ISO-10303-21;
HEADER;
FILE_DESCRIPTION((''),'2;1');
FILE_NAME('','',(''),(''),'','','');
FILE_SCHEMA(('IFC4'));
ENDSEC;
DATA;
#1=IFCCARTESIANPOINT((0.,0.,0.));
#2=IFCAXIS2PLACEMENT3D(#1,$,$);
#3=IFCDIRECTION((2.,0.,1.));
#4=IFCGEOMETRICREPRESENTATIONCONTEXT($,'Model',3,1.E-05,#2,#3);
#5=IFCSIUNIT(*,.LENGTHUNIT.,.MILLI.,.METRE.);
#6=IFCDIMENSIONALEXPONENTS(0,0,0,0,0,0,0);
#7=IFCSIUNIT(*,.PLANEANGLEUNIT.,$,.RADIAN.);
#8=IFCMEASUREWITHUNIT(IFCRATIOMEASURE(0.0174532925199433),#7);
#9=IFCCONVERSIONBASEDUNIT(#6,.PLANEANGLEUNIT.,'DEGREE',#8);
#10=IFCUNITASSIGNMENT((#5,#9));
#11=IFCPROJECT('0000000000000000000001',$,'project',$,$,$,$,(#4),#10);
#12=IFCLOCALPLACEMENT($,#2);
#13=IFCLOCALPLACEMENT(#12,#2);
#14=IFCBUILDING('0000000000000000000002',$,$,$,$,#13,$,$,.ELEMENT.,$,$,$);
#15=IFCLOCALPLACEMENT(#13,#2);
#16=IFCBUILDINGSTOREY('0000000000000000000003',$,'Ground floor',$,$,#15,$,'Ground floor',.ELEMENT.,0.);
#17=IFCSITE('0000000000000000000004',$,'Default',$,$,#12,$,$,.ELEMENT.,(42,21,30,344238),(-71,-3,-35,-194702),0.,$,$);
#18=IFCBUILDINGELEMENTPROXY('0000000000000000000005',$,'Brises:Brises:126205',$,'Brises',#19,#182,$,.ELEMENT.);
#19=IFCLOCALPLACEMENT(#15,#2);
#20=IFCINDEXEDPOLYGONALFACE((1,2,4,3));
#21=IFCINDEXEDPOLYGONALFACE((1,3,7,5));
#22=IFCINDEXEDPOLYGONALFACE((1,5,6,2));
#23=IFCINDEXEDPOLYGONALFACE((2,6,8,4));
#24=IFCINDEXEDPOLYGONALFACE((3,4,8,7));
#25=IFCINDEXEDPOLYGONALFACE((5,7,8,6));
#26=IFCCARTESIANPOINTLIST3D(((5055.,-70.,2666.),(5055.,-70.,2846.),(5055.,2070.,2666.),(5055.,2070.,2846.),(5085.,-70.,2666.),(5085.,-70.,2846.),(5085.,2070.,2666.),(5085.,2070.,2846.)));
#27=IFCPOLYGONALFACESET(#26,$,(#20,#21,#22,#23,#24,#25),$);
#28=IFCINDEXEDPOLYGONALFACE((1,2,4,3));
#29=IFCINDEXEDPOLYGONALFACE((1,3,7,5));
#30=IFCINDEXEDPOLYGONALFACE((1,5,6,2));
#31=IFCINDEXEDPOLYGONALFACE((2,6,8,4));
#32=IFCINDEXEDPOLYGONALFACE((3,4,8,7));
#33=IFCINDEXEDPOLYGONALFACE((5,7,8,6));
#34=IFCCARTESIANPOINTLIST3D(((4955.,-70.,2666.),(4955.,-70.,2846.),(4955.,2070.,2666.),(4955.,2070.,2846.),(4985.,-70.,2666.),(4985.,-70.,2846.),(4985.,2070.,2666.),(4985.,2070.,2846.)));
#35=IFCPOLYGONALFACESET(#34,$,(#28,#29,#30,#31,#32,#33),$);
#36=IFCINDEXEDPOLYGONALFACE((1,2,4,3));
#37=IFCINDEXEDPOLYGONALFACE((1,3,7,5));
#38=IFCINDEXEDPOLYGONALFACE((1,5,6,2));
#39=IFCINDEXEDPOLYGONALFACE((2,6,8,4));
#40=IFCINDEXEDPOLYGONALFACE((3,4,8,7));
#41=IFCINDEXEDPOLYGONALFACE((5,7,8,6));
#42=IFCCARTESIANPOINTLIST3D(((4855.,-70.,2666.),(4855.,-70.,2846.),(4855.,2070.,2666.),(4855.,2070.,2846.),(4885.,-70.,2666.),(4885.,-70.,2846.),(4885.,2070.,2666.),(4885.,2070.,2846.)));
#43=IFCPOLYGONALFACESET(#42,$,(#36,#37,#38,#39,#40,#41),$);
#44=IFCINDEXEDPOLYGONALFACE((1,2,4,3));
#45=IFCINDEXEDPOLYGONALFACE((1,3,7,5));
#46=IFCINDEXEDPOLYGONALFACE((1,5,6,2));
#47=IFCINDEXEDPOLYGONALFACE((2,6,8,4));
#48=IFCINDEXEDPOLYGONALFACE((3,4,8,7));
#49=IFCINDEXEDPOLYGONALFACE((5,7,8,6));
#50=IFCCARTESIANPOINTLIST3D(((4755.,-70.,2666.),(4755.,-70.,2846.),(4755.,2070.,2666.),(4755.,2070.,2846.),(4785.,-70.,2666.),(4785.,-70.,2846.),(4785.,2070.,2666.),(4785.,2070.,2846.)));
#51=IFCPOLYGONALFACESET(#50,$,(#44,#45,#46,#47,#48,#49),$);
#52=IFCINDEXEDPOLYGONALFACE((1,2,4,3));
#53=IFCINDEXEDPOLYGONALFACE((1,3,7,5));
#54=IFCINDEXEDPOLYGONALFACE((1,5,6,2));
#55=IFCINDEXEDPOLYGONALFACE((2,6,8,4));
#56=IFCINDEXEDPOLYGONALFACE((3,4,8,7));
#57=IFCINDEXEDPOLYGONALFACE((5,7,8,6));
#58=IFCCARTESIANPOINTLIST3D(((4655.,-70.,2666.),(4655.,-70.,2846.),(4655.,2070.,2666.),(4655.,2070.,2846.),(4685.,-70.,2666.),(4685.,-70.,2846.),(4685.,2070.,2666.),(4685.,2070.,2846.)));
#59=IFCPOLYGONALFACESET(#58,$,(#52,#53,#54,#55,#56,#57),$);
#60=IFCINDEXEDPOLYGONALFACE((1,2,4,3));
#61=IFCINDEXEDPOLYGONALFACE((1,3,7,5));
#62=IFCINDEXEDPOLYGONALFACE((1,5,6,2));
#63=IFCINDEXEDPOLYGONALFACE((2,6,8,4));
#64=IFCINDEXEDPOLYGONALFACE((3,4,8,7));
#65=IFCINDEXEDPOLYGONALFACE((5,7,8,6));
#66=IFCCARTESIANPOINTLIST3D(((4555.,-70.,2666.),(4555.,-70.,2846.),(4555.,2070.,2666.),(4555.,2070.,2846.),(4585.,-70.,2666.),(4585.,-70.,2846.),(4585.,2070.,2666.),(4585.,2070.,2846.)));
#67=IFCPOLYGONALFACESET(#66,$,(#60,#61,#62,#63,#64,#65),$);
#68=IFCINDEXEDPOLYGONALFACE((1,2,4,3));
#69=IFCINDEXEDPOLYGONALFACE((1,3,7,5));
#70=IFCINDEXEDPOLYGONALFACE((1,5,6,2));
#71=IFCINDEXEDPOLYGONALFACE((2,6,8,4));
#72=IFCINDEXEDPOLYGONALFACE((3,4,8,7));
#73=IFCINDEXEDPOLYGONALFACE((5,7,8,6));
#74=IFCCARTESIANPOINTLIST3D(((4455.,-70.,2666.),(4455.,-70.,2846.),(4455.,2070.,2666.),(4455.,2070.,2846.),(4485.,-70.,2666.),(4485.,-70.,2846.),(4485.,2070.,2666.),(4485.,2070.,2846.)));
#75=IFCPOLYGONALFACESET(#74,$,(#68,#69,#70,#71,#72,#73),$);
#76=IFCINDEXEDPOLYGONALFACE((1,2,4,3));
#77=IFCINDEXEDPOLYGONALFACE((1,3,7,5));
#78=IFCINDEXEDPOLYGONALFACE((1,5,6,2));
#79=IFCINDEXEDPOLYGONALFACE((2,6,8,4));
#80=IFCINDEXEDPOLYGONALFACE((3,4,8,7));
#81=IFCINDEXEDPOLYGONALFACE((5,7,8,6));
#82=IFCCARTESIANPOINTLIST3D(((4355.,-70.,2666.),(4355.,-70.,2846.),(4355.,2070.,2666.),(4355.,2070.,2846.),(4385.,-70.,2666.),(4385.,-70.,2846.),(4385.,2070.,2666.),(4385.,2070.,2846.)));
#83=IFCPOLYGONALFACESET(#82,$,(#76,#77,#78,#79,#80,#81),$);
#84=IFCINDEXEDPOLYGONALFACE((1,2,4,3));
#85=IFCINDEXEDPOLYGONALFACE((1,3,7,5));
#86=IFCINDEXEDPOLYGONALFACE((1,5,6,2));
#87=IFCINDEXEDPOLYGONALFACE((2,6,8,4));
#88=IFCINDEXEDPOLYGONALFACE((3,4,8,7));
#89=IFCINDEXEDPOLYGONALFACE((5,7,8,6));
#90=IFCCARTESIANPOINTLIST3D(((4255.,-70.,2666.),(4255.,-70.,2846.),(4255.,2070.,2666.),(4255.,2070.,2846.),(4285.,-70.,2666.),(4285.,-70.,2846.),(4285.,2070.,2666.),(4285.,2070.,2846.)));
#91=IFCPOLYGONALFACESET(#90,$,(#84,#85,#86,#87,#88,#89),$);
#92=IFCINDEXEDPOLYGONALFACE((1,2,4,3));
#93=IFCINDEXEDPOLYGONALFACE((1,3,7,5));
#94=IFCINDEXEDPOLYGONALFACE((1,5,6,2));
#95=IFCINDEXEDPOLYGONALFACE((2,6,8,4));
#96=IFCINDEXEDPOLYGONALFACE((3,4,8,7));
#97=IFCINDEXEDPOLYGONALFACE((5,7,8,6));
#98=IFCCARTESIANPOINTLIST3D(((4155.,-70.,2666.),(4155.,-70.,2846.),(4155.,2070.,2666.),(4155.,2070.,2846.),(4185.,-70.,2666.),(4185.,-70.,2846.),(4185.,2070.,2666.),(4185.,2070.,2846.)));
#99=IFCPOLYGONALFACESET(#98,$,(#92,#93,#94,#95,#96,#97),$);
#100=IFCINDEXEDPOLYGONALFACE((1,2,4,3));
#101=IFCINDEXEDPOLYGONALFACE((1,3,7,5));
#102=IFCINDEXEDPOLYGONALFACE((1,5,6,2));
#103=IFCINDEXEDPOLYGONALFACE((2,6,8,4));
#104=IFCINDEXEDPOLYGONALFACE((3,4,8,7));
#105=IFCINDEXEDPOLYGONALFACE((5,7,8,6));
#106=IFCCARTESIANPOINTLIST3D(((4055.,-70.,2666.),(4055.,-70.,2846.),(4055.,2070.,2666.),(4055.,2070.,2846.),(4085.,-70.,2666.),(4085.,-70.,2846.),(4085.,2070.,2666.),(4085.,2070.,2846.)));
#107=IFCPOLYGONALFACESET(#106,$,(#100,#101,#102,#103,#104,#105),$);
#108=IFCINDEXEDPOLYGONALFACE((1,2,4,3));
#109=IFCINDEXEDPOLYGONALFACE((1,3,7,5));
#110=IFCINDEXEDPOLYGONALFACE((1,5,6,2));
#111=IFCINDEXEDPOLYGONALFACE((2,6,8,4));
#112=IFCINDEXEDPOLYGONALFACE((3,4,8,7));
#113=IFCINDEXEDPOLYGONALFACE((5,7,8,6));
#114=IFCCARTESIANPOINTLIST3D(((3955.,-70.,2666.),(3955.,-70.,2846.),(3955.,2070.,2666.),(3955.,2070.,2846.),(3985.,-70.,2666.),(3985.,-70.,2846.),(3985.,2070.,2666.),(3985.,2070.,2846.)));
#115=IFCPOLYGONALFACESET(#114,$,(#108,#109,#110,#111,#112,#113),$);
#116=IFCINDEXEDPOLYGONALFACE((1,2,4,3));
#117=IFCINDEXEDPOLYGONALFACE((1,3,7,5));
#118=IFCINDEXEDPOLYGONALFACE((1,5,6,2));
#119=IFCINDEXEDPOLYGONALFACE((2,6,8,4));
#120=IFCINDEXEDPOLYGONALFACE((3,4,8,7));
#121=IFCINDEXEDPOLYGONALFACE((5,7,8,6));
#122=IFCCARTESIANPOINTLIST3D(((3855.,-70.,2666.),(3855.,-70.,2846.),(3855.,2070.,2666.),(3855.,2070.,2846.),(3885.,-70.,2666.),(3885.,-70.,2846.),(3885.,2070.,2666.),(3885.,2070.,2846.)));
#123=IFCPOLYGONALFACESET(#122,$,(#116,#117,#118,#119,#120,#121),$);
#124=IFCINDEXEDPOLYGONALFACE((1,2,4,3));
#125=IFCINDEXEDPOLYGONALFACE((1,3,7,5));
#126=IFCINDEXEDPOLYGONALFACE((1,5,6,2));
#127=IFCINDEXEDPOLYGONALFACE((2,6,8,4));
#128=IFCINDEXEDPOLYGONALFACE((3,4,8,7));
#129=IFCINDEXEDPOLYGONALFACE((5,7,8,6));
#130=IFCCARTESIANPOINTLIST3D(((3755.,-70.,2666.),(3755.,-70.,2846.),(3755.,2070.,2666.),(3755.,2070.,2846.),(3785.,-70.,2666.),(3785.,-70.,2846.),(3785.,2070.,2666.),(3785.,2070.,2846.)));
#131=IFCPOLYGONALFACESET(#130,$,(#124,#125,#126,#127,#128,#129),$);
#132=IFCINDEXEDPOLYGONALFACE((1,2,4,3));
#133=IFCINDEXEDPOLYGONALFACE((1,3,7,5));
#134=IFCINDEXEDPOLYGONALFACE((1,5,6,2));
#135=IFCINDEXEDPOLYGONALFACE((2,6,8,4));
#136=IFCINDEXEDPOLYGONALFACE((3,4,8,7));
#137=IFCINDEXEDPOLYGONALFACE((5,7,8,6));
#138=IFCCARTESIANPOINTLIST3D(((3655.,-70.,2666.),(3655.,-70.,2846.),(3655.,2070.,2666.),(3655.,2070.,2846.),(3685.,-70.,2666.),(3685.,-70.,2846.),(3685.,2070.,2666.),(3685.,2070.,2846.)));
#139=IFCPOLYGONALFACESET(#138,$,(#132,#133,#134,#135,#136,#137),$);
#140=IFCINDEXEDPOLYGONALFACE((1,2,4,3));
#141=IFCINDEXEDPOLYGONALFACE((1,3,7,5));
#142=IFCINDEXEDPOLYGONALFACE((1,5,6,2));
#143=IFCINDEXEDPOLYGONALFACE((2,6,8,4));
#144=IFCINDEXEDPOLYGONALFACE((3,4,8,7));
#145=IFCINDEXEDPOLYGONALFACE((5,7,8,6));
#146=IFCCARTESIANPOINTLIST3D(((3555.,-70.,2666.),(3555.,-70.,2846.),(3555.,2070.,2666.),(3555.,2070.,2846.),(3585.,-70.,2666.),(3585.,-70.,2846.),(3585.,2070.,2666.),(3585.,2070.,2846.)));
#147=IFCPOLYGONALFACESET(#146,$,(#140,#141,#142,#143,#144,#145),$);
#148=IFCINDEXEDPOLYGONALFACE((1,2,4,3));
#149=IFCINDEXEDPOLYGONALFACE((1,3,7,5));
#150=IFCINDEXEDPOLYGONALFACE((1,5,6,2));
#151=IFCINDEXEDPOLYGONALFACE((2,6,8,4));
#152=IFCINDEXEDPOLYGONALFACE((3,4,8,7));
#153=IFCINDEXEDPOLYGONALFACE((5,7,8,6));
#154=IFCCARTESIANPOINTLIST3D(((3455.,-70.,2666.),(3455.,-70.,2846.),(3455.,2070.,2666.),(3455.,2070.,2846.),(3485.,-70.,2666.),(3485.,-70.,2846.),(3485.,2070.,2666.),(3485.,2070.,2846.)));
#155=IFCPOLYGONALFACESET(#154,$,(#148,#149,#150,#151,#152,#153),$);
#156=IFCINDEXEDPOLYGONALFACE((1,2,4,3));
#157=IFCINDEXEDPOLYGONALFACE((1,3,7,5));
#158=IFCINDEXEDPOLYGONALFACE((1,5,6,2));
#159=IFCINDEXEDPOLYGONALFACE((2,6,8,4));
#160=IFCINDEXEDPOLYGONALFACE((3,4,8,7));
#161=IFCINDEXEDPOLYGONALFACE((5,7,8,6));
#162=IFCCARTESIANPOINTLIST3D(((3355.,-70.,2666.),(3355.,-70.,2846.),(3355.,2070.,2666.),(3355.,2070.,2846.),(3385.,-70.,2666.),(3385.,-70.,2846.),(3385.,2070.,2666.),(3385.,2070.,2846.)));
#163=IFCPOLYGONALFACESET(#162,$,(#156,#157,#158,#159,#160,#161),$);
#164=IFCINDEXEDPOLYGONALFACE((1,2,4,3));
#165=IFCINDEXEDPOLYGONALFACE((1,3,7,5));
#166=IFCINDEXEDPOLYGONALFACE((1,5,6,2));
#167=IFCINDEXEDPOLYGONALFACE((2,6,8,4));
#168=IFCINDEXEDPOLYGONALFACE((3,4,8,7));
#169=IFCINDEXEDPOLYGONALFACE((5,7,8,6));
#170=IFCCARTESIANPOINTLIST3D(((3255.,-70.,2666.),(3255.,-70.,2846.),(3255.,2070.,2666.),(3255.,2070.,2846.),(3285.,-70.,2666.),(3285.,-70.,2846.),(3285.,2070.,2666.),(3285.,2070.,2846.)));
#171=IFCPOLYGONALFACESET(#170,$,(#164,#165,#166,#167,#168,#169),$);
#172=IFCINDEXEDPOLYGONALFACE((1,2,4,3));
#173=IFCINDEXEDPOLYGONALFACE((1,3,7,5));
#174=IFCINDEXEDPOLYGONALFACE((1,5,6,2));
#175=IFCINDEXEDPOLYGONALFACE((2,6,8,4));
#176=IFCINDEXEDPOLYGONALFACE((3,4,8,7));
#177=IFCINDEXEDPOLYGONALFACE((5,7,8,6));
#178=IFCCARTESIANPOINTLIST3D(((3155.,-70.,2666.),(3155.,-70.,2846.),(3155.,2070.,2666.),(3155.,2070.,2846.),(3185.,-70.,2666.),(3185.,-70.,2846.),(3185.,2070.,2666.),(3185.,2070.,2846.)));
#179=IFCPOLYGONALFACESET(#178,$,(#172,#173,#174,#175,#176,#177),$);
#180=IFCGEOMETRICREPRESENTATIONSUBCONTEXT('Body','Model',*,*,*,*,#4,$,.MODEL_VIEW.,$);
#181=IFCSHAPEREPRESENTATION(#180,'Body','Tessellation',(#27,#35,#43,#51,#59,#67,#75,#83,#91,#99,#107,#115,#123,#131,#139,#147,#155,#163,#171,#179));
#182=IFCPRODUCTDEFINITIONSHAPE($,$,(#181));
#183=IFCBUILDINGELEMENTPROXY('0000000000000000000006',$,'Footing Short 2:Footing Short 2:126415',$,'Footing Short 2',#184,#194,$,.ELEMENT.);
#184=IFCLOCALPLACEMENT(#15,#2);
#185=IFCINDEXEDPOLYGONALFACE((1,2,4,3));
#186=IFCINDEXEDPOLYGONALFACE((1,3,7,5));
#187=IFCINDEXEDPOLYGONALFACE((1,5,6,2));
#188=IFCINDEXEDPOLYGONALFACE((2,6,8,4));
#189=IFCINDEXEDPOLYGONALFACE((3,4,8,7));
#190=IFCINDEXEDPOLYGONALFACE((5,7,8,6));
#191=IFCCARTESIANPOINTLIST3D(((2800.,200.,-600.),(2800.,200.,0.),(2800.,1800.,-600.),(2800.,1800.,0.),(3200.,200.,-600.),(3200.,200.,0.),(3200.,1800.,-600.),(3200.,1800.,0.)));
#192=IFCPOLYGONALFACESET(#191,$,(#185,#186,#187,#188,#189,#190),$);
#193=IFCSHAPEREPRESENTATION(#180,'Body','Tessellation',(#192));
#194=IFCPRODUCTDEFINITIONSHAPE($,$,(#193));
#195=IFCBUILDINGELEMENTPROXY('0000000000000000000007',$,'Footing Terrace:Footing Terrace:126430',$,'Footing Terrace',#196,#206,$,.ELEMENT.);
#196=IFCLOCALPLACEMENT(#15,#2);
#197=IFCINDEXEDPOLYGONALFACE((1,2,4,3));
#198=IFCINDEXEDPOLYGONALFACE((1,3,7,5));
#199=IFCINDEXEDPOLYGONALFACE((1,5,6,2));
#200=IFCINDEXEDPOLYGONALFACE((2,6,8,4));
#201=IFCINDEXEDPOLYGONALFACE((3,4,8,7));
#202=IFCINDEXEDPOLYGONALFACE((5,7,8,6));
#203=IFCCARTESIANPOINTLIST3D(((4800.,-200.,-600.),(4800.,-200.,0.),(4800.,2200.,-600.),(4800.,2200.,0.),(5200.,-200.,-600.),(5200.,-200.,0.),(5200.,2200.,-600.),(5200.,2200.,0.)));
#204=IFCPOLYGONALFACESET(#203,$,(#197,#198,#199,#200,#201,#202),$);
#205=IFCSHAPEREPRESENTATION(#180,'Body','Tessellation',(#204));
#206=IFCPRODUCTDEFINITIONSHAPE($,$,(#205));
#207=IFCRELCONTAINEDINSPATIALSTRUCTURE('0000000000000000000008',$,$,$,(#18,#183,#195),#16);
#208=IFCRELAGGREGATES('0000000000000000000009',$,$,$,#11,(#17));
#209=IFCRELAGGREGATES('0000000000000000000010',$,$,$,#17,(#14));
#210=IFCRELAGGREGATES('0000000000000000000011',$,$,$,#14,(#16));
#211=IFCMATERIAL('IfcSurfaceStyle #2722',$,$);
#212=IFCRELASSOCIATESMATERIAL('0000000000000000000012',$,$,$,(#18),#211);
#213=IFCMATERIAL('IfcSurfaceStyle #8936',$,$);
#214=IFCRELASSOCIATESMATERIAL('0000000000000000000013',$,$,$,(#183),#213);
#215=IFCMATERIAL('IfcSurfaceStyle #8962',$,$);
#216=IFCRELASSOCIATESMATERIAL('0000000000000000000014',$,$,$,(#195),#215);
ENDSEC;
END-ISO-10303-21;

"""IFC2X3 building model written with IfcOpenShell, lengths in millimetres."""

from ifc_helpers import new_model, entity, si_unit, converted_unit, direction, frame, frame_2d, origin, origin_2d_with_axis, place, context, subcontext, project, spatial, rectangle, extrude, source, transform, mapped, material, element, save


model = new_model("IFC2X3")

# Units and contexts
model_context = context("Model", 3, precision=1e-05, world=origin(), true_north=direction((2.0, 0.0, 1.0)))
body_context = subcontext(model_context, "Body", "Model", "MODEL_VIEW")
ifc_project = project(units=[si_unit("LENGTHUNIT", "METRE", prefix="MILLI"), converted_unit("PLANEANGLEUNIT", "DEGREE", entity("IfcRatioMeasure", 0.0174532925199433), si_unit("PLANEANGLEUNIT", "RADIAN"), dimensions=[0, 0, 0, 0, 0, 0, 0])], contexts=[model_context])

# Site, building, storey
site_placement = place(None, origin())
site = spatial("IfcSite", under=ifc_project, at=site_placement, Name="Default", CompositionType="ELEMENT", RefLatitude=(42, 21, 30, 344238), RefLongitude=(-71, -3, -35, -194702), RefElevation=0.0)
building_placement = place(site_placement, origin())
building = spatial("IfcBuilding", under=site, at=building_placement, CompositionType="ELEMENT")
storey_placement = place(building_placement, origin())
storey = spatial("IfcBuildingStorey", under=building, at=storey_placement, Name="Ground floor", LongName="Ground floor", CompositionType="ELEMENT", Elevation=0.0)

# Building element proxies
ifc_material_1 = material(Name="IfcSurfaceStyle #2722")
shared_shape_1 = source(origin(), body_context, "Body", "SweptSolid", [
    extrude(rectangle(XDim=2140.0, YDim=30.0, at=frame_2d((0.0, 0.0), x_axis=(1.0, 0.0))), frame((1915.0, 1070.0, 0.0), z_axis=(0.0, 0.0, 1.0), x_axis=(0.0, -1.0, 0.0)), (0.0, 0.0, 1.0), 180.0),
    extrude(rectangle(XDim=2140.0, YDim=30.0, at=frame_2d((0.0, 0.0), x_axis=(1.0, 0.0))), frame((1815.0, 1070.0, 0.0), z_axis=(0.0, 0.0, 1.0), x_axis=(0.0, -1.0, 0.0)), (0.0, 0.0, 1.0), 180.0),
    extrude(rectangle(XDim=2140.0, YDim=30.0, at=frame_2d((0.0, 0.0), x_axis=(1.0, 0.0))), frame((1715.0, 1070.0, 0.0), z_axis=(0.0, 0.0, 1.0), x_axis=(0.0, -1.0, 0.0)), (0.0, 0.0, 1.0), 180.0),
    extrude(rectangle(XDim=2140.0, YDim=30.0, at=origin_2d_with_axis()), frame((1615.0, 1070.0, 0.0), z_axis=(0.0, 0.0, 1.0), x_axis=(0.0, -1.0, 0.0)), (0.0, 0.0, 1.0), 180.0),
    extrude(rectangle(XDim=2140.0, YDim=30.0, at=origin_2d_with_axis()), frame((1515.0, 1070.0, 0.0), z_axis=(0.0, 0.0, 1.0), x_axis=(0.0, -1.0, 0.0)), (0.0, 0.0, 1.0), 180.0),
    extrude(rectangle(XDim=2140.0, YDim=30.0, at=origin_2d_with_axis()), frame((1415.0, 1070.0, 0.0), z_axis=(0.0, 0.0, 1.0), x_axis=(0.0, -1.0, 0.0)), (0.0, 0.0, 1.0), 180.0),
    extrude(rectangle(XDim=2140.0, YDim=30.0, at=origin_2d_with_axis()), frame((1315.0, 1070.0, 0.0), z_axis=(0.0, 0.0, 1.0), x_axis=(0.0, -1.0, 0.0)), (0.0, 0.0, 1.0), 180.0),
    extrude(rectangle(XDim=2140.0, YDim=30.0, at=origin_2d_with_axis()), frame((1215.0, 1070.0, 0.0), z_axis=(0.0, 0.0, 1.0), x_axis=(0.0, -1.0, 0.0)), (0.0, 0.0, 1.0), 180.0),
    extrude(rectangle(XDim=2140.0, YDim=30.0, at=origin_2d_with_axis()), frame((1115.0, 1070.0, 0.0), z_axis=(0.0, 0.0, 1.0), x_axis=(0.0, -1.0, 0.0)), (0.0, 0.0, 1.0), 180.0),
    extrude(rectangle(XDim=2140.0, YDim=30.0, at=origin_2d_with_axis()), frame((1015.0, 1070.0, 0.0), z_axis=(0.0, 0.0, 1.0), x_axis=(0.0, -1.0, 0.0)), (0.0, 0.0, 1.0), 180.0),
    extrude(rectangle(XDim=2140.0, YDim=30.0, at=origin_2d_with_axis()), frame((915.0, 1070.0, 0.0), z_axis=(0.0, 0.0, 1.0), x_axis=(0.0, -1.0, 0.0)), (0.0, 0.0, 1.0), 180.0),
    extrude(rectangle(XDim=2140.0, YDim=30.0, at=origin_2d_with_axis()), frame((815.0, 1070.0, 0.0), z_axis=(0.0, 0.0, 1.0), x_axis=(0.0, -1.0, 0.0)), (0.0, 0.0, 1.0), 180.0),
    extrude(rectangle(XDim=2140.0, YDim=30.0, at=origin_2d_with_axis()), frame((715.0, 1070.0, 0.0), z_axis=(0.0, 0.0, 1.0), x_axis=(0.0, -1.0, 0.0)), (0.0, 0.0, 1.0), 180.0),
    extrude(rectangle(XDim=2140.0, YDim=30.0, at=origin_2d_with_axis()), frame((615.0, 1070.0, 0.0), z_axis=(0.0, 0.0, 1.0), x_axis=(0.0, -1.0, 0.0)), (0.0, 0.0, 1.0), 180.0),
    extrude(rectangle(XDim=2140.0, YDim=30.0, at=origin_2d_with_axis()), frame((515.0, 1070.0, 0.0), z_axis=(0.0, 0.0, 1.0), x_axis=(0.0, -1.0, 0.0)), (0.0, 0.0, 1.0), 180.0),
    extrude(rectangle(XDim=2140.0, YDim=30.0, at=origin_2d_with_axis()), frame((415.0, 1070.0, 0.0), z_axis=(0.0, 0.0, 1.0), x_axis=(0.0, -1.0, 0.0)), (0.0, 0.0, 1.0), 180.0),
    extrude(rectangle(XDim=2140.0, YDim=30.0, at=origin_2d_with_axis()), frame((315.0, 1070.0, 0.0), z_axis=(0.0, 0.0, 1.0), x_axis=(0.0, -1.0, 0.0)), (0.0, 0.0, 1.0), 180.0),
    extrude(rectangle(XDim=2140.0, YDim=30.0, at=origin_2d_with_axis()), frame((215.0, 1070.0, 0.0), z_axis=(0.0, 0.0, 1.0), x_axis=(0.0, -1.0, 0.0)), (0.0, 0.0, 1.0), 180.0),
    extrude(rectangle(XDim=2140.0, YDim=30.0, at=origin_2d_with_axis()), frame((115.0, 1070.0, 0.0), z_axis=(0.0, 0.0, 1.0), x_axis=(0.0, -1.0, 0.0)), (0.0, 0.0, 1.0), 180.0),
    extrude(rectangle(XDim=2140.0, YDim=30.0, at=origin_2d_with_axis()), frame((15.0, 1070.0, 0.0), z_axis=(0.0, 0.0, 1.0), x_axis=(0.0, -1.0, 0.0)), (0.0, 0.0, 1.0), 180.0),
])
proxy_1_placement = place(building_placement, frame((3155.0, -70.0, 2666.0)))
element("IfcBuildingElementProxy", 1, at=proxy_1_placement, inside=storey, material=ifc_material_1, Name="Brises:Brises:126205", ObjectType="Brises", CompositionType="ELEMENT", context=body_context, shape_type="MappedRepresentation", body=[
    mapped(shared_shape_1, transform((0.0, 0.0, 0.0), scale=1.0)),
])
ifc_material_2 = material(Name="IfcSurfaceStyle #8936")
shared_shape_2 = source(origin(), body_context, "Body", "SweptSolid", [
    extrude(rectangle(XDim=1600.0, YDim=400.0, at=origin_2d_with_axis()), frame((200.0, 800.0, 0.0), z_axis=(0.0, 0.0, 1.0), x_axis=(0.0, -1.0, 0.0)), (0.0, 0.0, 1.0), 600.0),
])
proxy_2_placement = place(building_placement, frame((2800.0, 200.0, -600.0)))
element("IfcBuildingElementProxy", 2, at=proxy_2_placement, inside=storey, material=ifc_material_2, Name="Footing Short 2:Footing Short 2:126415", ObjectType="Footing Short 2", CompositionType="ELEMENT", context=body_context, shape_type="MappedRepresentation", body=[
    mapped(shared_shape_2, transform((0.0, 0.0, 0.0), scale=1.0)),
])
ifc_material_3 = material(Name="IfcSurfaceStyle #8962")
shared_shape_3 = source(origin(), body_context, "Body", "SweptSolid", [
    extrude(rectangle(XDim=2400.0, YDim=400.0, at=origin_2d_with_axis()), frame((200.0, 1200.0, 0.0), z_axis=(0.0, 0.0, 1.0), x_axis=(0.0, -1.0, 0.0)), (0.0, 0.0, 1.0), 600.0),
])
proxy_3_placement = place(building_placement, frame((4800.0, -200.0, -600.0)))
element("IfcBuildingElementProxy", 3, at=proxy_3_placement, inside=storey, material=ifc_material_3, Name="Footing Terrace:Footing Terrace:126430", ObjectType="Footing Terrace", CompositionType="ELEMENT", context=body_context, shape_type="MappedRepresentation", body=[
    mapped(shared_shape_3, transform((0.0, 0.0, 0.0), scale=1.0)),
])

save(model, "model.ifc")
